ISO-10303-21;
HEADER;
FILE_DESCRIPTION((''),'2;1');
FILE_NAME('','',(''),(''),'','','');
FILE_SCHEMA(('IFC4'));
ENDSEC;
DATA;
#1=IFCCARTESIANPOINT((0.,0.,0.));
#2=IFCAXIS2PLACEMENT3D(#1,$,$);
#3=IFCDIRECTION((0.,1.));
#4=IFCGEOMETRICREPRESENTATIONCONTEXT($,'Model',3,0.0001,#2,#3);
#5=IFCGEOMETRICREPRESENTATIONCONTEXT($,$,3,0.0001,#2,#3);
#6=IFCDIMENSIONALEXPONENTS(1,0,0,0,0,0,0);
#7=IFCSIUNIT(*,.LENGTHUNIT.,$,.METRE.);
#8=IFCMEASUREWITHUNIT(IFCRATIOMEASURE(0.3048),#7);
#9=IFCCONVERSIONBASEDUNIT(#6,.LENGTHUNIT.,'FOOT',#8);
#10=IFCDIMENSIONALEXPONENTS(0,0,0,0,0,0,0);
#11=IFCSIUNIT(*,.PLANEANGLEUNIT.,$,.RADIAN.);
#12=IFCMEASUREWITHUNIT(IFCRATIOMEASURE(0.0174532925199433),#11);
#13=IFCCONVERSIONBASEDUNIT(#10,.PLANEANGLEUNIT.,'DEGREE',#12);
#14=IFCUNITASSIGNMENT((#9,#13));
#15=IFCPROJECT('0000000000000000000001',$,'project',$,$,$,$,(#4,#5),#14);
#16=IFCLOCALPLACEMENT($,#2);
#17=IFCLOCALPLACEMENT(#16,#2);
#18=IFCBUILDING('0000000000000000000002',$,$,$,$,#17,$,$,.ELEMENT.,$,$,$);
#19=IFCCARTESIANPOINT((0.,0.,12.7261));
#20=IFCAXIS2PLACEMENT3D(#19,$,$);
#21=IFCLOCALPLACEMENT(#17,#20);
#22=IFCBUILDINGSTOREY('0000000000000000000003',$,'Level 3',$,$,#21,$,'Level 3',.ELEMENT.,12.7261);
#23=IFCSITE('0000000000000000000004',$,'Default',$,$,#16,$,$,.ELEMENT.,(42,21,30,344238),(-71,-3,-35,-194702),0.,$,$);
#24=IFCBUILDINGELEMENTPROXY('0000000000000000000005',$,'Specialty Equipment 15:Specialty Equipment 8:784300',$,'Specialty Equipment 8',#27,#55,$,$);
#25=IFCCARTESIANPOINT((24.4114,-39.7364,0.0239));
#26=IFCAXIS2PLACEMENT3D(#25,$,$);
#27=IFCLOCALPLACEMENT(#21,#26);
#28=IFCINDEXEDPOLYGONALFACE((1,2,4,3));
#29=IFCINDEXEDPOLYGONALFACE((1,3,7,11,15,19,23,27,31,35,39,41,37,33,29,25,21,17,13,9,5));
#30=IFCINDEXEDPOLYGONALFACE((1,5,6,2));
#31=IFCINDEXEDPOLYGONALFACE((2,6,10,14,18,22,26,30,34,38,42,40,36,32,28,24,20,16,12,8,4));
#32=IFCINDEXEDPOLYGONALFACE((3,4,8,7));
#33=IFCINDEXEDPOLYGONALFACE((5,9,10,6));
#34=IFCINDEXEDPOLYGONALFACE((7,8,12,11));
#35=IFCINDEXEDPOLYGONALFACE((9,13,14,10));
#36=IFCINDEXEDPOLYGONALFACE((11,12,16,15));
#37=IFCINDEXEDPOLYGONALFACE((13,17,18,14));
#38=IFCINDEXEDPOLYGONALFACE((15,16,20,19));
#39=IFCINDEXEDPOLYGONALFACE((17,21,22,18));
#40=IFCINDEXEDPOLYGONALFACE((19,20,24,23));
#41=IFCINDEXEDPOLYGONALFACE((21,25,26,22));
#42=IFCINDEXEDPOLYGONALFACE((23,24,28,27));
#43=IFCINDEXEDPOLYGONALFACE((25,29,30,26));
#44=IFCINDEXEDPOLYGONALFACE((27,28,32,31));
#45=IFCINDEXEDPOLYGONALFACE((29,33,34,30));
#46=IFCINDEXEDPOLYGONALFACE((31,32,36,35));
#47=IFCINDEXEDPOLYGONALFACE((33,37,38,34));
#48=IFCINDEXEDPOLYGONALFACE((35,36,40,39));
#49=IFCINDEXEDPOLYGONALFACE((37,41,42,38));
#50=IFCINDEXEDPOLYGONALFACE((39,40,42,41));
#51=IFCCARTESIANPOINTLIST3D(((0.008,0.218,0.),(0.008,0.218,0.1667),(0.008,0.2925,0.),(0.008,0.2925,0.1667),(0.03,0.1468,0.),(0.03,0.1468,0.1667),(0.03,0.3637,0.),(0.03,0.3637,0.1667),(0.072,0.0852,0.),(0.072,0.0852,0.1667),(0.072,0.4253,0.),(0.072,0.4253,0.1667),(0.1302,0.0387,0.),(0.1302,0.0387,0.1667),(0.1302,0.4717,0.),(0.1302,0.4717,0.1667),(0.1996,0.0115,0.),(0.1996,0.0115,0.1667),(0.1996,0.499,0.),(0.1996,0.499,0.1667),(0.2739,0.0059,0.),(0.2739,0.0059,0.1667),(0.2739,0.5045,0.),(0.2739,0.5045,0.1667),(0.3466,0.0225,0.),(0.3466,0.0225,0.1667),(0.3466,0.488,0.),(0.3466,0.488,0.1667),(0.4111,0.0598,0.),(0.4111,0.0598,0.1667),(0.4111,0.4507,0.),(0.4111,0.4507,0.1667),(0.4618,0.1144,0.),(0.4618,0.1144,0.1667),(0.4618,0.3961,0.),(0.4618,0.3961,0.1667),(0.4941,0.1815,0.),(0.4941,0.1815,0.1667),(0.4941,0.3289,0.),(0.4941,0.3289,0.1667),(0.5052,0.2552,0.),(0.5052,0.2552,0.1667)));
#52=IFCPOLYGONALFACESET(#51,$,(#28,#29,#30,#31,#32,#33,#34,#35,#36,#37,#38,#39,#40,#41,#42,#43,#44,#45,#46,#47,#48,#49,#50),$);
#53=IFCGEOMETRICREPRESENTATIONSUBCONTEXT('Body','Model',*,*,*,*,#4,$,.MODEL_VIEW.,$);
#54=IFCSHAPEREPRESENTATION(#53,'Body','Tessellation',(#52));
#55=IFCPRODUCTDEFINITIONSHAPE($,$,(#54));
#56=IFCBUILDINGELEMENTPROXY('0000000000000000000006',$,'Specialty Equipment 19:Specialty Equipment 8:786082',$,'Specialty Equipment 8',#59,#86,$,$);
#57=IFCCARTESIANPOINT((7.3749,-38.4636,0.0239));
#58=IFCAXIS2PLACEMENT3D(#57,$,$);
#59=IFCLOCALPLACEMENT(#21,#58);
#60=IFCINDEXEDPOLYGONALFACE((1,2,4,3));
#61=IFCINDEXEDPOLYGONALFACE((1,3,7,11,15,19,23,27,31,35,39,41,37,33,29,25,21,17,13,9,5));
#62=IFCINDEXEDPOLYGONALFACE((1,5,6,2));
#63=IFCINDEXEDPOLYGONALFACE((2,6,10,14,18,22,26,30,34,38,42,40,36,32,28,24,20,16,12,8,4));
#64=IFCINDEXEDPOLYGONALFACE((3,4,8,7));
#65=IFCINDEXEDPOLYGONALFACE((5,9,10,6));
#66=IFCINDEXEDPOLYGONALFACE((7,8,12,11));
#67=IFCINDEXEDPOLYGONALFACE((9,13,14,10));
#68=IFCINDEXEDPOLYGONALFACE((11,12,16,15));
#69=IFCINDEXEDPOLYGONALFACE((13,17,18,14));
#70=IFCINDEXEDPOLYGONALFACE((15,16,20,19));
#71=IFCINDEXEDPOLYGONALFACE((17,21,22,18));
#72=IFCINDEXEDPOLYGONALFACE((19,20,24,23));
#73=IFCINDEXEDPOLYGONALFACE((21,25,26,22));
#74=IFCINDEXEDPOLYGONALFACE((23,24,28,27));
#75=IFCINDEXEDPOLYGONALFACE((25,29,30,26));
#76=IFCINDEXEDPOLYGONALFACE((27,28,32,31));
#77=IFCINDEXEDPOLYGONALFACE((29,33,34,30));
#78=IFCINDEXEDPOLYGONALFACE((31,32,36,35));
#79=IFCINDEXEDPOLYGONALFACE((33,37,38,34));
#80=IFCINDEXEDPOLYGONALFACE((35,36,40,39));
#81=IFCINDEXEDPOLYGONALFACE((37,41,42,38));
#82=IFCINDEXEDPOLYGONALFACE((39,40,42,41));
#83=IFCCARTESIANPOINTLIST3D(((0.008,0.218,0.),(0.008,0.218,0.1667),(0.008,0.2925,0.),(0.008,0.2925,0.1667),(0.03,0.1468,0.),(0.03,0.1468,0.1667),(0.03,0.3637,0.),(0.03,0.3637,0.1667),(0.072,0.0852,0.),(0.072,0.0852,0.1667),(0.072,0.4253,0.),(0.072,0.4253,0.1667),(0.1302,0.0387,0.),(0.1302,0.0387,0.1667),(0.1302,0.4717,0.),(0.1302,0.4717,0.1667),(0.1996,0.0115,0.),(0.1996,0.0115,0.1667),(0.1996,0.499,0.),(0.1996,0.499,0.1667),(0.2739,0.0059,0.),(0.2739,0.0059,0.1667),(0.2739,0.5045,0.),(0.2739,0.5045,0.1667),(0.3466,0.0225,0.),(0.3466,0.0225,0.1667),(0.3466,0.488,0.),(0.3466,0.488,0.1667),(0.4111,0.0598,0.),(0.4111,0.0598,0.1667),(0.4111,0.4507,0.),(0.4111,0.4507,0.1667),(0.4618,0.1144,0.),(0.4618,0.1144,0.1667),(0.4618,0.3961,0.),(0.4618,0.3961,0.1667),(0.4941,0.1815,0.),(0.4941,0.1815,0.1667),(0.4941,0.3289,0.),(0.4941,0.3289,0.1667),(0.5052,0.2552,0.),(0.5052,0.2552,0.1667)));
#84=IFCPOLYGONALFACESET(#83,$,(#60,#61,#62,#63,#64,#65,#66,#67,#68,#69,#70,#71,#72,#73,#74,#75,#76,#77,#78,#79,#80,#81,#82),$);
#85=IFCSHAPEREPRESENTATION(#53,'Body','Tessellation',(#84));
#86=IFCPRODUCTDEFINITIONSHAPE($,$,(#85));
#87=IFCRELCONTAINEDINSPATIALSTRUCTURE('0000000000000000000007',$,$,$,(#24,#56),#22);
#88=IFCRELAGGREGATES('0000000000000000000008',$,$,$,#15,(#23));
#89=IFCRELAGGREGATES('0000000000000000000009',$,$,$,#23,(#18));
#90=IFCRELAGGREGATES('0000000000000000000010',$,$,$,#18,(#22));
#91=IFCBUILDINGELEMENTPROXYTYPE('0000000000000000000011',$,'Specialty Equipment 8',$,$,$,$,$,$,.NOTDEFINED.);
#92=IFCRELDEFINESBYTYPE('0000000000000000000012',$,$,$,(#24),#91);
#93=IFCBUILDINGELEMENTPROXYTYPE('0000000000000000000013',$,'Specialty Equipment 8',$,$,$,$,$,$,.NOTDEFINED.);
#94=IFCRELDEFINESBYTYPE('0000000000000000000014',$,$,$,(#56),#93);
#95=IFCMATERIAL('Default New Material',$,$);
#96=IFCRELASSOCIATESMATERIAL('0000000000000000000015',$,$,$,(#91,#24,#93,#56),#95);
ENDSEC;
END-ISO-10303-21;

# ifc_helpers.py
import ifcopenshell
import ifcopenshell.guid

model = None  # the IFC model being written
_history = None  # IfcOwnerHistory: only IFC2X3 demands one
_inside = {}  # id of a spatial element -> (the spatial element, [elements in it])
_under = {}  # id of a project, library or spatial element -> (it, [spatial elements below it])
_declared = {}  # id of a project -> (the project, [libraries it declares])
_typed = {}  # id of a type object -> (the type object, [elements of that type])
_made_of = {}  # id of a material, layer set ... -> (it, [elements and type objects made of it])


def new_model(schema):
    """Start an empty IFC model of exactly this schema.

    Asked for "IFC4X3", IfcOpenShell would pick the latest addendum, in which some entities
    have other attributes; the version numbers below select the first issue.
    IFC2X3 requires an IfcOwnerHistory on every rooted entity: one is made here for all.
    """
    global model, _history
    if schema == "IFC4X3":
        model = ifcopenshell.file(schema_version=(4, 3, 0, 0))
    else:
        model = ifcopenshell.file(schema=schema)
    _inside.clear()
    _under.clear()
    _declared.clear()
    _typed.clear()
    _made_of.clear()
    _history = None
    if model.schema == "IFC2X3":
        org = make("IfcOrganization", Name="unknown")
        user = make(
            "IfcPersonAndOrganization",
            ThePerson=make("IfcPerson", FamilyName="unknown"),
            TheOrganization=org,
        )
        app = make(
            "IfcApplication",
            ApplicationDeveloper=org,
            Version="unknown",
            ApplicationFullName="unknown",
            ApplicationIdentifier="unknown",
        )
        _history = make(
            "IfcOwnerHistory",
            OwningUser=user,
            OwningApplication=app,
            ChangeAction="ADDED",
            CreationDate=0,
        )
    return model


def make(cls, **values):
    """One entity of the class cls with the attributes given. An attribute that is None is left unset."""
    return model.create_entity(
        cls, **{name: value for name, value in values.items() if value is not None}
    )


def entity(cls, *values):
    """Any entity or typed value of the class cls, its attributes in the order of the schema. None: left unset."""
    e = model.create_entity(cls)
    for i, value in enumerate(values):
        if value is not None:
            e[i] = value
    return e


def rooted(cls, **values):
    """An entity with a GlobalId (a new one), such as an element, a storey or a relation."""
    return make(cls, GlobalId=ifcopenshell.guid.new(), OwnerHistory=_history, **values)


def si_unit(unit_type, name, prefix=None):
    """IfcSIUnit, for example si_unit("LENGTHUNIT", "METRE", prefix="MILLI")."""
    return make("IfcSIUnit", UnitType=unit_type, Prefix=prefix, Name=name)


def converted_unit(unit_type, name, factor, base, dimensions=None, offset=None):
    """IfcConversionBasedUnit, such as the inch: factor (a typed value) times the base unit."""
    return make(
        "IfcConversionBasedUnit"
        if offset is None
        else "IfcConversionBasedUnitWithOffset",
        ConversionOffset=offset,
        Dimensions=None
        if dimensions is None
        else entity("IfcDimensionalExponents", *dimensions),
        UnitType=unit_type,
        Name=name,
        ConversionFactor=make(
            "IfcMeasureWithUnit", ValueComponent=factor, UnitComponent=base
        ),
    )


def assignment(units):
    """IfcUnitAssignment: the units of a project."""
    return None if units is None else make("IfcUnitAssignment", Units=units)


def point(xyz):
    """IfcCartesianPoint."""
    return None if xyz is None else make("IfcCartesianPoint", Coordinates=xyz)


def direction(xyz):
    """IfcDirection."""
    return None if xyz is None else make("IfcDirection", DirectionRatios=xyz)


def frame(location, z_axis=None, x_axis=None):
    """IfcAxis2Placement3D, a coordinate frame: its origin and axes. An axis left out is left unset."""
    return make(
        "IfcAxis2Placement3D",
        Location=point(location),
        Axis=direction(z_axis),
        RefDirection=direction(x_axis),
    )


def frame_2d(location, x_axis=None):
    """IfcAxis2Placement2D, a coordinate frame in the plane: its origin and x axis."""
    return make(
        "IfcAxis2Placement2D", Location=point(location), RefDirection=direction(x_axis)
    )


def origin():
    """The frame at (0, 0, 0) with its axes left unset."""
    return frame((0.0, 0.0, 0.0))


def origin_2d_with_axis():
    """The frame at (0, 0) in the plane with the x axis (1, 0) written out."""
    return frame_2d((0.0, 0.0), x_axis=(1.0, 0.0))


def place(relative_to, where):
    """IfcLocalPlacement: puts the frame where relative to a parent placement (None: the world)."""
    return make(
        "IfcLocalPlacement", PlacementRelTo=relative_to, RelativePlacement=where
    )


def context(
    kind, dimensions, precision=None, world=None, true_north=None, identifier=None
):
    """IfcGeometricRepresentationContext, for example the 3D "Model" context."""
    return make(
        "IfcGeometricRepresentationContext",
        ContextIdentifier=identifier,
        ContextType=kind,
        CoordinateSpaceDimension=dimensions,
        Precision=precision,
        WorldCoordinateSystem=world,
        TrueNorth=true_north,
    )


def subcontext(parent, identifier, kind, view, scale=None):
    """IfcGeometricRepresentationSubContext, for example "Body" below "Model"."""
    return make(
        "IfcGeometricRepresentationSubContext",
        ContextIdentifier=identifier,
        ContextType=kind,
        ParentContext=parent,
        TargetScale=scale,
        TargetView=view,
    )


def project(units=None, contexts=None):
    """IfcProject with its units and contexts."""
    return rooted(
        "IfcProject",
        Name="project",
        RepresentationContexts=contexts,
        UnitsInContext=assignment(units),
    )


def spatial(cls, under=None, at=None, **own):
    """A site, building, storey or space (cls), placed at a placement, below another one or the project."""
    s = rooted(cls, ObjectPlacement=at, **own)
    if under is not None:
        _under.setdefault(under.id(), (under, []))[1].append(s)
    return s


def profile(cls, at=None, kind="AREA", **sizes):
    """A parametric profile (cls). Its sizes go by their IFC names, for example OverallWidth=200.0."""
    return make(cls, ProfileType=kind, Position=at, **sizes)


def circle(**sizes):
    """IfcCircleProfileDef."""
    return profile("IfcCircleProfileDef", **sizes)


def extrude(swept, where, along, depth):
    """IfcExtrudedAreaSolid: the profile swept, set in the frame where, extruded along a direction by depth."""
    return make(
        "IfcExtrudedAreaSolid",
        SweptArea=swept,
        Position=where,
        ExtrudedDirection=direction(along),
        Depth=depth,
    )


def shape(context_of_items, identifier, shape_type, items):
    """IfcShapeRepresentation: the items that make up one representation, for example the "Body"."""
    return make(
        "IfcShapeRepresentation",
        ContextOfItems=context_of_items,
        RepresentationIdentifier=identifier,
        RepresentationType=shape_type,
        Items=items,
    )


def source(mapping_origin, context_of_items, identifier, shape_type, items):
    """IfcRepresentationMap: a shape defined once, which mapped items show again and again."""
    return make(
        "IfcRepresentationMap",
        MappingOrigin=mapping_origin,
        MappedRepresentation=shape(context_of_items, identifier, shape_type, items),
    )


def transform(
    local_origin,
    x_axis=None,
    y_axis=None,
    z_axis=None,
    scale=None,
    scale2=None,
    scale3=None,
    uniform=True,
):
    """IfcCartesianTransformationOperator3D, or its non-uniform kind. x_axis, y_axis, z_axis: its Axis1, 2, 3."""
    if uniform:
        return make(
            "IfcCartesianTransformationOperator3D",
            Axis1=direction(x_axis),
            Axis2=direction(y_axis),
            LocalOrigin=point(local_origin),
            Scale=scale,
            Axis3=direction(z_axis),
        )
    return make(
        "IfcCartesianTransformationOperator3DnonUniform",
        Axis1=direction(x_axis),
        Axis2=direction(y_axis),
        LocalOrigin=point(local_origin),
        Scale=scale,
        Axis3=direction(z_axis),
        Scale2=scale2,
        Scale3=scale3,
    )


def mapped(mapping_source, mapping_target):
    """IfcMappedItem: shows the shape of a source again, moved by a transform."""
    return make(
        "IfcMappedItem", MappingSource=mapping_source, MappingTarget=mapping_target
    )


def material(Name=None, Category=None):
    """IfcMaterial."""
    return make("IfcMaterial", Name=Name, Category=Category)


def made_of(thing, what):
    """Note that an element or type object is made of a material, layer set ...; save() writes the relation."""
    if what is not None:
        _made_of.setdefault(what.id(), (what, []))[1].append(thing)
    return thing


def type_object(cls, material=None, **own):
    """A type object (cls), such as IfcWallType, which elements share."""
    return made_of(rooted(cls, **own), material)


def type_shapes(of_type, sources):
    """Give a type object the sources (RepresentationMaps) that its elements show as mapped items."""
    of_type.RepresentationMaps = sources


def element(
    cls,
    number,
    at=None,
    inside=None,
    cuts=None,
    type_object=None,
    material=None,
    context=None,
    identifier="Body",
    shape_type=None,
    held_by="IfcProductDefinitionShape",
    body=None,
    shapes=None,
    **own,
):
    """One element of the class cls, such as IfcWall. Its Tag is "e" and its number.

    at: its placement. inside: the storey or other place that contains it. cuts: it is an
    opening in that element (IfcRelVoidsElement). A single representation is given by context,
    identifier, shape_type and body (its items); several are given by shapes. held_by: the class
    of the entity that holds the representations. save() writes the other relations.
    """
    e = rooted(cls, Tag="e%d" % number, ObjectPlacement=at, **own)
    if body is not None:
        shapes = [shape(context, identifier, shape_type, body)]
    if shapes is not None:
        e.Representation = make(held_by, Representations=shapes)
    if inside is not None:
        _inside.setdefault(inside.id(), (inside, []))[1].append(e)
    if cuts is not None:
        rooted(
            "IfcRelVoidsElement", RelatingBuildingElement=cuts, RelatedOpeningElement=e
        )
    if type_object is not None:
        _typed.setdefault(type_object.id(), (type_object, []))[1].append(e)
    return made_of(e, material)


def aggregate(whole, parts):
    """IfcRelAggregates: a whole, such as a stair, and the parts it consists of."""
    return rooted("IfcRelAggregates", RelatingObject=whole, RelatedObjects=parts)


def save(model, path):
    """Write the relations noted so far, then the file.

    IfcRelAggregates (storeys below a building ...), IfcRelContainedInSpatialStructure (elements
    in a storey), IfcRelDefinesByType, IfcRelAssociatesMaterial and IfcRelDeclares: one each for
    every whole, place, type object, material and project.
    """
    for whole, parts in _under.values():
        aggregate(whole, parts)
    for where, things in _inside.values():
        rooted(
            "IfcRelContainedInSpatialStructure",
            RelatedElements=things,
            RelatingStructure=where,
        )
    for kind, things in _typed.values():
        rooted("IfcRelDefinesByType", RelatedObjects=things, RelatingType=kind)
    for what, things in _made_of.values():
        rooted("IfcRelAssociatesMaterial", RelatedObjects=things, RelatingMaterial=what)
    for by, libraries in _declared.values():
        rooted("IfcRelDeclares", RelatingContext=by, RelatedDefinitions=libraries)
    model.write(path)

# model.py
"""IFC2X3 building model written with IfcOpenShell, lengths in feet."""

from ifc_helpers import new_model, entity, si_unit, converted_unit, direction, frame, origin, origin_2d_with_axis, place, context, subcontext, project, spatial, circle, extrude, source, transform, mapped, material, type_object, type_shapes, element, save


model = new_model("IFC2X3")

# Units and contexts
model_context = context("Model", 3, precision=0.0001, world=origin(), true_north=direction((0.0, 1.0)))
context_of_model = context(None, 3, precision=0.0001, world=origin(), true_north=direction((0.0, 1.0)))
body_context = subcontext(model_context, "Body", "Model", "MODEL_VIEW")
ifc_project = project(units=[converted_unit("LENGTHUNIT", "FOOT", entity("IfcRatioMeasure", 0.3048), si_unit("LENGTHUNIT", "METRE"), dimensions=[1, 0, 0, 0, 0, 0, 0]), converted_unit("PLANEANGLEUNIT", "DEGREE", entity("IfcRatioMeasure", 0.0174532925199433), si_unit("PLANEANGLEUNIT", "RADIAN"), dimensions=[0, 0, 0, 0, 0, 0, 0])], contexts=[model_context, context_of_model])

# Site, building, storey
site_placement = place(None, origin())
site = spatial("IfcSite", under=ifc_project, at=site_placement, Name="Default", CompositionType="ELEMENT", RefLatitude=(42, 21, 30, 344238), RefLongitude=(-71, -3, -35, -194702), RefElevation=0.0)
building_placement = place(site_placement, origin())
building = spatial("IfcBuilding", under=site, at=building_placement, CompositionType="ELEMENT")
storey_placement = place(building_placement, frame((0.0, 0.0, 12.7261)))
storey = spatial("IfcBuildingStorey", under=building, at=storey_placement, Name="Level 3", LongName="Level 3", CompositionType="ELEMENT", Elevation=12.7261)

# Shared definitions
ifc_material = material(Name="Default New Material")

# Building element proxies
building_element_proxy_type_1 = type_object("IfcBuildingElementProxyType", Name="Specialty Equipment 8", PredefinedType="NOTDEFINED", material=ifc_material)
shared_shape_1 = source(origin(), body_context, "Body", "SweptSolid", [
    extrude(circle(Radius=0.25, at=origin_2d_with_axis()), frame((0.2552, 0.2552, 0.0)), (0.0, 0.0, 1.0), 0.1667),
])
type_shapes(building_element_proxy_type_1, [shared_shape_1])
proxy_1_placement = place(storey_placement, frame((24.4114, -39.7364, 0.0239)))
element("IfcBuildingElementProxy", 1, at=proxy_1_placement, inside=storey, type_object=building_element_proxy_type_1, material=ifc_material, Name="Specialty Equipment 15:Specialty Equipment 8:784300", ObjectType="Specialty Equipment 8", context=body_context, shape_type="MappedRepresentation", body=[
    mapped(shared_shape_1, transform((0.0, 0.0, 0.0), scale=1.0)),
])
building_element_proxy_type_2 = type_object("IfcBuildingElementProxyType", Name="Specialty Equipment 8", PredefinedType="NOTDEFINED", material=ifc_material)
shared_shape_2 = source(origin(), body_context, "Body", "SweptSolid", [
    extrude(circle(Radius=0.25, at=origin_2d_with_axis()), frame((0.2552, 0.2552, 0.0)), (0.0, 0.0, 1.0), 0.1667),
])
type_shapes(building_element_proxy_type_2, [shared_shape_2])
proxy_2_placement = place(storey_placement, frame((7.3749, -38.4636, 0.0239)))
element("IfcBuildingElementProxy", 2, at=proxy_2_placement, inside=storey, type_object=building_element_proxy_type_2, material=ifc_material, Name="Specialty Equipment 19:Specialty Equipment 8:786082", ObjectType="Specialty Equipment 8", context=body_context, shape_type="MappedRepresentation", body=[
    mapped(shared_shape_2, transform((0.0, 0.0, 0.0), scale=1.0)),
])

save(model, "model.ifc")
